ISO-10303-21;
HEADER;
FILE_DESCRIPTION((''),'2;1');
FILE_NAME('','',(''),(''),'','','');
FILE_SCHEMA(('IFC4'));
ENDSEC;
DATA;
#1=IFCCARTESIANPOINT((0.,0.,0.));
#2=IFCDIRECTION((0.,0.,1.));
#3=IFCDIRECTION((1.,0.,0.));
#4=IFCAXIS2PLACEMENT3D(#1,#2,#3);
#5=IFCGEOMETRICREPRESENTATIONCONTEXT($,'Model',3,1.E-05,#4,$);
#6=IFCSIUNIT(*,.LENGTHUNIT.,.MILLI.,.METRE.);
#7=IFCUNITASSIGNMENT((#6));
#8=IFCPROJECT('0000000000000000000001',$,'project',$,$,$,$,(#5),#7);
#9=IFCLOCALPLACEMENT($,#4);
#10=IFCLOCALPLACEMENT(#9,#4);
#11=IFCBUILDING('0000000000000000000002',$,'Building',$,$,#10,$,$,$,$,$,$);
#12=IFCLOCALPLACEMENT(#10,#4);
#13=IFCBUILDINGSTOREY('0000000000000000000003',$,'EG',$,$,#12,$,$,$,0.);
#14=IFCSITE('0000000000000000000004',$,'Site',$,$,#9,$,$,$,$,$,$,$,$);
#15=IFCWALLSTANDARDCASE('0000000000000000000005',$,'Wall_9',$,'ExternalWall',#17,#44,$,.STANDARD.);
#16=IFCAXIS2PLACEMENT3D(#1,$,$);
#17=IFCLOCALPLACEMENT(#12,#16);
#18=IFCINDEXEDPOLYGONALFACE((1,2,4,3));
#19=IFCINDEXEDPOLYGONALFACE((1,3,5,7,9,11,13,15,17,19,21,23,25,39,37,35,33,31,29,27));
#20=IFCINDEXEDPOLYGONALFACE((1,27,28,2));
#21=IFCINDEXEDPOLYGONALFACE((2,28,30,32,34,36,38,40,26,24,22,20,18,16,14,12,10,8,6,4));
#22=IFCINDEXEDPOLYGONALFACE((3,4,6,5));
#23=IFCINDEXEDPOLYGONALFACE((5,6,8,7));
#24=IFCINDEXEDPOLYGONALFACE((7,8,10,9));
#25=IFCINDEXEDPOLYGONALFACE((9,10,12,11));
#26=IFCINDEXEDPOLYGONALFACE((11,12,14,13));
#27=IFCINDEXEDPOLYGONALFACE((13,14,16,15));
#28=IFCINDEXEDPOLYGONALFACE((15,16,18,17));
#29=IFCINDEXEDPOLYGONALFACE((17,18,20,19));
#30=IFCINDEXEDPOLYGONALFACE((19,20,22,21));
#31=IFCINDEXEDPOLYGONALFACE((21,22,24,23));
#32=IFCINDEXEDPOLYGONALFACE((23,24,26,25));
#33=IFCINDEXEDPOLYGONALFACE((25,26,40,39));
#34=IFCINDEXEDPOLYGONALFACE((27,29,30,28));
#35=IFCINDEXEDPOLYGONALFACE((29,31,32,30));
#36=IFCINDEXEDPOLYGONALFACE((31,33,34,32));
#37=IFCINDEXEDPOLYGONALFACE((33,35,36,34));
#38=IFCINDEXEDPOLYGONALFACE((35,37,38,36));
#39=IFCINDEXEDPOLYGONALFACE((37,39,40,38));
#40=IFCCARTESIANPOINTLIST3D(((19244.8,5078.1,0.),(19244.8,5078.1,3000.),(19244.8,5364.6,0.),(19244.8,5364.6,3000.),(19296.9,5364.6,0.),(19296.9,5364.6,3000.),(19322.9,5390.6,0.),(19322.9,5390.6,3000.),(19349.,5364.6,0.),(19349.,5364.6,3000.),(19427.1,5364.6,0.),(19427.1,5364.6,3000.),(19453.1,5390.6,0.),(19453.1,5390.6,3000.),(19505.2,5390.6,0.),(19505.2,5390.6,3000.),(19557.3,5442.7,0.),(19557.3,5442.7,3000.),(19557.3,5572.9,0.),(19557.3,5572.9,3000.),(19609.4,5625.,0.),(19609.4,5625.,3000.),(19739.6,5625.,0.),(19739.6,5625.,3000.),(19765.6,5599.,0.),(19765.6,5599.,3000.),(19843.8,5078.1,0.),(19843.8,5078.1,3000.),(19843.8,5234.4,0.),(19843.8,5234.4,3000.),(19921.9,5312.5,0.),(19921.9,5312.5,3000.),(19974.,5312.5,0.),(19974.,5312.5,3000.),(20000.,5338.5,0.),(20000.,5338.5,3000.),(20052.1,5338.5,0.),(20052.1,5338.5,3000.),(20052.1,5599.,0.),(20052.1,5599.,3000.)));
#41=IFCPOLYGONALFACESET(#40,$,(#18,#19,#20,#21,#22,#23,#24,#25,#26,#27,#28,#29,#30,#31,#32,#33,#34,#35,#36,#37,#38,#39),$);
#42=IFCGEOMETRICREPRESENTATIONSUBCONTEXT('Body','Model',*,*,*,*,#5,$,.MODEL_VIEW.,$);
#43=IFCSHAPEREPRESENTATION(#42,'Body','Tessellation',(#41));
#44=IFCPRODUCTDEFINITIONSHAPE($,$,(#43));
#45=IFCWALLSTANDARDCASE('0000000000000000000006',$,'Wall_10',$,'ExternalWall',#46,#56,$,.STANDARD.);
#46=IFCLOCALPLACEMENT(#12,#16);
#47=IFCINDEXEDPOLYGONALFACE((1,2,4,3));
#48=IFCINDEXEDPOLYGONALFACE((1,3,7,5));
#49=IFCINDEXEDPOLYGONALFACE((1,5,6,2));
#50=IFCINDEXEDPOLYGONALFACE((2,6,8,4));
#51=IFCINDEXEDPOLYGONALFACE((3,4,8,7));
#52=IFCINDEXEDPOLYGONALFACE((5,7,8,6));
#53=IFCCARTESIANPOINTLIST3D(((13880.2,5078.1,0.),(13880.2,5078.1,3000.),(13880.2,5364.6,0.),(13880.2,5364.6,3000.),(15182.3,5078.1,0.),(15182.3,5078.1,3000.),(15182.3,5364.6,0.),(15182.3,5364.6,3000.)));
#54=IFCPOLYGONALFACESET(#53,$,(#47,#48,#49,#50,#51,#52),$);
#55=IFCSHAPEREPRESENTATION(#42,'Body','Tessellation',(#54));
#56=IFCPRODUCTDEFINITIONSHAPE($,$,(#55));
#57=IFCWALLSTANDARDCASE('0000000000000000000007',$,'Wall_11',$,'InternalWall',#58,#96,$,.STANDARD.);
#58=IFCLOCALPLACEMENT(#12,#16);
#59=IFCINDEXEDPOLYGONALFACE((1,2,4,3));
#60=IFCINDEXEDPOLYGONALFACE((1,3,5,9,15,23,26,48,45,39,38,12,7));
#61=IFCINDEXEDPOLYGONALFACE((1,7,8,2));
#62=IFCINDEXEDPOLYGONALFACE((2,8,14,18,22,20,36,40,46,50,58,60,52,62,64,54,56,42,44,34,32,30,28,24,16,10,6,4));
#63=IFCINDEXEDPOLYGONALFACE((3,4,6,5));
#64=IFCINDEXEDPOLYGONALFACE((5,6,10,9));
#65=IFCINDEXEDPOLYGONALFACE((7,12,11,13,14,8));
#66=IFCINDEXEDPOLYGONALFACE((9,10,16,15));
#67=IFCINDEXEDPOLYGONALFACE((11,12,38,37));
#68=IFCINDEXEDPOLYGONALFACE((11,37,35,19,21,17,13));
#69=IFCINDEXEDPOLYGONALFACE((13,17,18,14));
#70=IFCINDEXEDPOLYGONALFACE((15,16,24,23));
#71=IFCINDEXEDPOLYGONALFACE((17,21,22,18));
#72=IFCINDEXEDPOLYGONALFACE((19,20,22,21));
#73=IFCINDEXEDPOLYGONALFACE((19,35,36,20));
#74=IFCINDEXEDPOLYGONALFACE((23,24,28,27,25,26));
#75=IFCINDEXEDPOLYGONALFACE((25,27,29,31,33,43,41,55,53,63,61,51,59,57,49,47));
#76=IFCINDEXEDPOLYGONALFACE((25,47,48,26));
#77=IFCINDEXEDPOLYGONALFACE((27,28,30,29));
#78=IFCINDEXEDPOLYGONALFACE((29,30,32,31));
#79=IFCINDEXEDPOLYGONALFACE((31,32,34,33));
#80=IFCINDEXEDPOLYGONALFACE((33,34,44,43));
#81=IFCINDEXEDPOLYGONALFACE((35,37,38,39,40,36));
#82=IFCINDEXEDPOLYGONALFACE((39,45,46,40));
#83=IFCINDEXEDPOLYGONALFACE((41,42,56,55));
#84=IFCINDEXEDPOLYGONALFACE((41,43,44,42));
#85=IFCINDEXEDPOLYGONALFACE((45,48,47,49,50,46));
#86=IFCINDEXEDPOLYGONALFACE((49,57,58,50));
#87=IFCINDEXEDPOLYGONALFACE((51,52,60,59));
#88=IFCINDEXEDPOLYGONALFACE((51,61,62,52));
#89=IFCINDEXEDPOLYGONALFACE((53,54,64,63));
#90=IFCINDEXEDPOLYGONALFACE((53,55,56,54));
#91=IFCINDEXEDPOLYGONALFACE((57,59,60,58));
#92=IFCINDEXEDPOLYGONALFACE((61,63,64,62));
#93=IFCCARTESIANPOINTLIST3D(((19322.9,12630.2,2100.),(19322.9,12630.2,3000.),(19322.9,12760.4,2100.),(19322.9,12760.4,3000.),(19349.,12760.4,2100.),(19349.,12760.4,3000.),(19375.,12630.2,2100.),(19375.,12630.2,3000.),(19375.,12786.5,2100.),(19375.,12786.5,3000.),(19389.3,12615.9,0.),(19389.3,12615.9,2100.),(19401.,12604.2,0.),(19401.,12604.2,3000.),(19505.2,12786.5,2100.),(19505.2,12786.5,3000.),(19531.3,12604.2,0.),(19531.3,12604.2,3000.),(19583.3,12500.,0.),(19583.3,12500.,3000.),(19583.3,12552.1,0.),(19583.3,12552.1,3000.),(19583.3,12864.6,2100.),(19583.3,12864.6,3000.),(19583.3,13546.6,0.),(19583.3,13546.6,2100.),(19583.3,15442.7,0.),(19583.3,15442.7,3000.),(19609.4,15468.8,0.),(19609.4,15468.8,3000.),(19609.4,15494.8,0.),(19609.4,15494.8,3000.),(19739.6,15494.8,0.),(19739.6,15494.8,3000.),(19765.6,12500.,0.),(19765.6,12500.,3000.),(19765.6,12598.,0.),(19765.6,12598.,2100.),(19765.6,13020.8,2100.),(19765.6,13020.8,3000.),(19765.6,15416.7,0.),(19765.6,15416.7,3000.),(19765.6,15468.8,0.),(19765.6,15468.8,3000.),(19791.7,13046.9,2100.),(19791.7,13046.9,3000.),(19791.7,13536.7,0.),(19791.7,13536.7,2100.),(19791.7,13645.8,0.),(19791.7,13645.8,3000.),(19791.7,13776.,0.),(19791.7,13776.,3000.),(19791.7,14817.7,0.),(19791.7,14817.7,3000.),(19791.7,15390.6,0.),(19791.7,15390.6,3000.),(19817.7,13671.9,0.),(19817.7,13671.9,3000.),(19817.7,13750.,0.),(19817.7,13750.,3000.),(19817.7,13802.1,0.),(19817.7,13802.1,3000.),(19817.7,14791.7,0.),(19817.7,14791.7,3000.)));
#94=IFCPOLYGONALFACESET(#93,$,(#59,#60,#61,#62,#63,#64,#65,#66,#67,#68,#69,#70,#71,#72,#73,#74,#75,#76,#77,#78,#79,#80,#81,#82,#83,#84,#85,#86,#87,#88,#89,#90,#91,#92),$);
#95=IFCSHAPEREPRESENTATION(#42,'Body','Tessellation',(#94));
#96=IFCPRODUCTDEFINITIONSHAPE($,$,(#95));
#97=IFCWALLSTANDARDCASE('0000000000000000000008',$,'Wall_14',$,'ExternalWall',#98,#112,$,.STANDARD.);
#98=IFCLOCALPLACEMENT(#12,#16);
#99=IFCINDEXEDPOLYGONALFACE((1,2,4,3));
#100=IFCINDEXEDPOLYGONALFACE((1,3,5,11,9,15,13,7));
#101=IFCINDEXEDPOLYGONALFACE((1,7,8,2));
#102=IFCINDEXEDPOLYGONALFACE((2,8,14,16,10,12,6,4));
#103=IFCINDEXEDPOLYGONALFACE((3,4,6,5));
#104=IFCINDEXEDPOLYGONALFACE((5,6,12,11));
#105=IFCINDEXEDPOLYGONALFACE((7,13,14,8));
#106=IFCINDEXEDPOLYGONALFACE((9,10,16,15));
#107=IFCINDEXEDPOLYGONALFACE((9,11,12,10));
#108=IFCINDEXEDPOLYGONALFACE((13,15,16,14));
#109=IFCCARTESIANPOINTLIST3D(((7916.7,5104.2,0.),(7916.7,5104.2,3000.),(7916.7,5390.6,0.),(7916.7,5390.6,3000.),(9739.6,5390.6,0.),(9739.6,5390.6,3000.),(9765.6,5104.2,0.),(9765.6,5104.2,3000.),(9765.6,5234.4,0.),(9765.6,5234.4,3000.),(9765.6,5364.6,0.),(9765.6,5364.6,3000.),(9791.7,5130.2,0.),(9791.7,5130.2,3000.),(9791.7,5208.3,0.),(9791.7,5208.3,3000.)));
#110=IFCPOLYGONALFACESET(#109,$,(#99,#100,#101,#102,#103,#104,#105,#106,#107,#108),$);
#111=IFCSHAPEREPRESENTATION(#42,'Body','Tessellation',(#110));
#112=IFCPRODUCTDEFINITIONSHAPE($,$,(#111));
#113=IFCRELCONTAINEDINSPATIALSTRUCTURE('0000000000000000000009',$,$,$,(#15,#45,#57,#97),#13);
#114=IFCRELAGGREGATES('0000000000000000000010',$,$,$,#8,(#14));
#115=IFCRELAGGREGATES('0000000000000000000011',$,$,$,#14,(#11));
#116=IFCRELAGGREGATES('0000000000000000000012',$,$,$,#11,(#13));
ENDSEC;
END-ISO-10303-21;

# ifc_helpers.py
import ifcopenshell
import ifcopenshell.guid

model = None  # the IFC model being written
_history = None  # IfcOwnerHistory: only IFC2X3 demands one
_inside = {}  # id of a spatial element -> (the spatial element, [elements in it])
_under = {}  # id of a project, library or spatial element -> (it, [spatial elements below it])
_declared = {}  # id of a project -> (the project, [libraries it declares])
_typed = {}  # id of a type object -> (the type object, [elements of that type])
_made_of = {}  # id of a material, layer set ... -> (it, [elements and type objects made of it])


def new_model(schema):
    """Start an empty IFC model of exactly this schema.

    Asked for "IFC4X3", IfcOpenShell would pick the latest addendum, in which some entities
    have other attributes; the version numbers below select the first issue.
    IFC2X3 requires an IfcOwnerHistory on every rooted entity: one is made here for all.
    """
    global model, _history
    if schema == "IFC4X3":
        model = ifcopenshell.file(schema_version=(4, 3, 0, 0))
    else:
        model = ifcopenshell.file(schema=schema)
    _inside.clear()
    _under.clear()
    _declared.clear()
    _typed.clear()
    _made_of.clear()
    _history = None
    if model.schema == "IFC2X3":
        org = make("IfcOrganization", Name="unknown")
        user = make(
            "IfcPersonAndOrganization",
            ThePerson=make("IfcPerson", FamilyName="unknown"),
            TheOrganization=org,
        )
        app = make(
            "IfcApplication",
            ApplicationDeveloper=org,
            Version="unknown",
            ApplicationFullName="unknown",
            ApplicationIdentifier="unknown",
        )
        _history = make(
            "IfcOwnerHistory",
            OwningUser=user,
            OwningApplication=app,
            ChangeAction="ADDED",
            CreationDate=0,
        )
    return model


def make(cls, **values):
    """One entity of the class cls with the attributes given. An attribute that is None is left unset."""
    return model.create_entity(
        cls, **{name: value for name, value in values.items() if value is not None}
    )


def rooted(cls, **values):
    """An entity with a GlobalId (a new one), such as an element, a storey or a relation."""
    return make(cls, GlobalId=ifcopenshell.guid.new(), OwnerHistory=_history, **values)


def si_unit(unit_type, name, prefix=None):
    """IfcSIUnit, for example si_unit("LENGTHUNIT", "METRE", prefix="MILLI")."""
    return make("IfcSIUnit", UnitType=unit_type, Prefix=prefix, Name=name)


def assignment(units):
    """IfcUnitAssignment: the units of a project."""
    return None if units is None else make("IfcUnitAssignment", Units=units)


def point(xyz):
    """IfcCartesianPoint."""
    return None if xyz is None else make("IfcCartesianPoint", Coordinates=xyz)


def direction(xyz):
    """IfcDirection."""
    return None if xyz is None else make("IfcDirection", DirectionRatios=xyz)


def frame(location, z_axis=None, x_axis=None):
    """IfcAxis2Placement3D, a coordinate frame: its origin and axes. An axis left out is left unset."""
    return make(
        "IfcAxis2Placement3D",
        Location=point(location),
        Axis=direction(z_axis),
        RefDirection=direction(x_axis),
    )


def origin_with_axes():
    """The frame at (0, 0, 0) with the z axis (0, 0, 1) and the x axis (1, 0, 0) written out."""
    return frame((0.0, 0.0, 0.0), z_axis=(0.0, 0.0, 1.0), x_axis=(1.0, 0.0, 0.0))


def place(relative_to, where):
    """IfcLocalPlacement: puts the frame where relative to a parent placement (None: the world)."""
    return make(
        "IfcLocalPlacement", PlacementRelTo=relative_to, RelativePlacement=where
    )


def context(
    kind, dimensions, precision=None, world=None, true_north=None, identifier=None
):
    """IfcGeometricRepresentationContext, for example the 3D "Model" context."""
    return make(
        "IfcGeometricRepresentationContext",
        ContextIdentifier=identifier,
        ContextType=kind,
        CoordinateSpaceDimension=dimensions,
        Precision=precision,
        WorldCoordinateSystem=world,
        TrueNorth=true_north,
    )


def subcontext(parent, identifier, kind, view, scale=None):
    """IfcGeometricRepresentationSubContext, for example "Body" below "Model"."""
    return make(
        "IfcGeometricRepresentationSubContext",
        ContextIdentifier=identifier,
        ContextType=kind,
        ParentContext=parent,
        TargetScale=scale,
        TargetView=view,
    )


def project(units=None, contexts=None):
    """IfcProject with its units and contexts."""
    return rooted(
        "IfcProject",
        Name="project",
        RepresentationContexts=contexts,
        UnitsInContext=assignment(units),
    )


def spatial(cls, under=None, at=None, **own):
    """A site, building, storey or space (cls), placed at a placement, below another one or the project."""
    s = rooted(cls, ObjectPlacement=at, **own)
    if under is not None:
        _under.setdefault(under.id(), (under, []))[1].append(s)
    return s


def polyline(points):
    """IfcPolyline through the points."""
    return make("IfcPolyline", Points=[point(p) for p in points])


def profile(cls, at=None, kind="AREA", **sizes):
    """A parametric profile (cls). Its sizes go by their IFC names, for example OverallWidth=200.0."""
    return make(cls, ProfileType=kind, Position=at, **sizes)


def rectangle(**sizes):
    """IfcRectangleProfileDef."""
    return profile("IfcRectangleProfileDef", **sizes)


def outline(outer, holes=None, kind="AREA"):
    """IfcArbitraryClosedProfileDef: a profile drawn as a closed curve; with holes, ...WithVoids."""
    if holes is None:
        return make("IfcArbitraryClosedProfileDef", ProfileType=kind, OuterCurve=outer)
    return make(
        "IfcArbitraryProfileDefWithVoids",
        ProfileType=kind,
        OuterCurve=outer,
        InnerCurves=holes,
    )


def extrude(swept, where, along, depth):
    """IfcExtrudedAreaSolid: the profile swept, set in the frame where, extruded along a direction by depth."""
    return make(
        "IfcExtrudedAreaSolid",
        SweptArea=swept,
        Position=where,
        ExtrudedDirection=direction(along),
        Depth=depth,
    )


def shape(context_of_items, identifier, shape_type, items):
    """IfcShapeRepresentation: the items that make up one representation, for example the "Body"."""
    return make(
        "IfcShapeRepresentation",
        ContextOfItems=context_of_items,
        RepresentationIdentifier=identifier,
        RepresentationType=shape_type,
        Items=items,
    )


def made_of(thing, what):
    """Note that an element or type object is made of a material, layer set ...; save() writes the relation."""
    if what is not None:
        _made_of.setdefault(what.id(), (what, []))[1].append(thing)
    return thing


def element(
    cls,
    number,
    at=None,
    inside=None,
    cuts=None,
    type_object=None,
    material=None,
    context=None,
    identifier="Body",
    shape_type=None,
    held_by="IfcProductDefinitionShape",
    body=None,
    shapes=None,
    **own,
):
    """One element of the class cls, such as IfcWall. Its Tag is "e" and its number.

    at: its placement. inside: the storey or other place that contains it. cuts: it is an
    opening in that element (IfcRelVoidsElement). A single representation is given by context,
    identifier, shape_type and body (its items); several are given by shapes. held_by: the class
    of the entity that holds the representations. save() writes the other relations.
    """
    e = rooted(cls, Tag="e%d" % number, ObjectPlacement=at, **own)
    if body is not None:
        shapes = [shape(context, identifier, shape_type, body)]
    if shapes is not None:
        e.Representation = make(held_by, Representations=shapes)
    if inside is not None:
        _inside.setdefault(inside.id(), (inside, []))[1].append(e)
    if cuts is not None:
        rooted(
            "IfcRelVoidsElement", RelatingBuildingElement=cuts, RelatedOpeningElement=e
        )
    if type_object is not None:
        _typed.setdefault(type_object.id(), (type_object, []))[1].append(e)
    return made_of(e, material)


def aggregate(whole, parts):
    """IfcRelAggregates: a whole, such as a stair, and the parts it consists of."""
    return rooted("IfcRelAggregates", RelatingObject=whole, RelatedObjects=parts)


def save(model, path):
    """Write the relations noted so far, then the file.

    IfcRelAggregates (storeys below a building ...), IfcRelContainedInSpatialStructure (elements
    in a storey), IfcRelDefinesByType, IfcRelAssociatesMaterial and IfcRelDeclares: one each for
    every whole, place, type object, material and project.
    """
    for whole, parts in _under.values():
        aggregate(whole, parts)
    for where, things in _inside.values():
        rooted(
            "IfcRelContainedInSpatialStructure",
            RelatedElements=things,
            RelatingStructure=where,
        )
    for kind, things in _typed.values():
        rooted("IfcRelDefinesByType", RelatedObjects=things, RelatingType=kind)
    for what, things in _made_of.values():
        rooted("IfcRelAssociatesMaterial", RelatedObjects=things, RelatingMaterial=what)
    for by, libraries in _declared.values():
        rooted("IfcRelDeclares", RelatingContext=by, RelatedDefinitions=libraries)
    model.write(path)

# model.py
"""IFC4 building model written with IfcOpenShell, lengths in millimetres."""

from ifc_helpers import new_model, si_unit, frame, origin_with_axes, place, context, subcontext, project, spatial, polyline, rectangle, outline, extrude, element, save


model = new_model("IFC4")

# Units and contexts
model_context = context("Model", 3, precision=1e-05, world=origin_with_axes())
body_context = subcontext(model_context, "Body", "Model", "MODEL_VIEW")
ifc_project = project(units=[si_unit("LENGTHUNIT", "METRE", prefix="MILLI")], contexts=[model_context])

# Site, building, storey
site_placement = place(None, origin_with_axes())
site = spatial("IfcSite", under=ifc_project, at=site_placement, Name="Site")
building_placement = place(site_placement, origin_with_axes())
building = spatial("IfcBuilding", under=site, at=building_placement, Name="Building")
storey_placement = place(building_placement, origin_with_axes())
storey = spatial("IfcBuildingStorey", under=building, at=storey_placement, Name="EG", Elevation=0.0)

# Wall, openings
wall_1_placement = place(storey_placement, origin_with_axes())
wall_1 = element("IfcWallStandardCase", 1, at=wall_1_placement, inside=storey, Name="Wall_9", ObjectType="ExternalWall", PredefinedType="STANDARD", context=body_context, shape_type="SweptSolid", body=[
    extrude(outline(polyline([(19244.8, 5078.1, 0.0), (19244.8, 5364.6, 0.0), (19296.9, 5364.6, 0.0), (19322.9, 5390.6, 0.0), (19349.0, 5364.6, 0.0), (19427.1, 5364.6, 0.0), (19453.1, 5390.6, 0.0), (19505.2, 5390.6, 0.0), (19557.3, 5442.7, 0.0), (19557.3, 5572.9, 0.0), (19609.4, 5625.0, 0.0), (19739.6, 5625.0, 0.0), (19765.6, 5599.0, 0.0), (20052.1, 5599.0, 0.0), (20052.1, 5338.5, 0.0), (20000.0, 5338.5, 0.0), (19974.0, 5312.5, 0.0), (19921.9, 5312.5, 0.0), (19843.8, 5234.4, 0.0), (19843.8, 5078.1, 0.0), (19244.8, 5078.1, 0.0)])), origin_with_axes(), (0.0, 0.0, 1.0), 3000.0),
])
opening_1_placement = place(wall_1_placement, origin_with_axes())
element("IfcOpeningElement", 2, at=opening_1_placement, inside=storey, cuts=wall_1, context=body_context, shape_type="SweptSolid", body=[
    extrude(rectangle(XDim=1200.0, YDim=546.9), frame((18580.7, 5208.1, 1000.0), z_axis=(0.0, 0.0, 1.0), x_axis=(1.0, 0.0, 0.0)), (0.0, 0.0, 1.0), 1000.0),
])
opening_2_placement = place(wall_1_placement, origin_with_axes())
element("IfcOpeningElement", 3, at=opening_2_placement, inside=storey, cuts=wall_1, context=body_context, shape_type="SweptSolid", body=[
    extrude(rectangle(XDim=1200.0, YDim=546.9), frame((21822.9, 5507.8, 1000.0), z_axis=(0.0, 0.0, 1.0), x_axis=(1.0, 0.0, 0.0)), (0.0, 0.0, 1.0), 1000.0),
])

# Wall
wall_2_placement = place(storey_placement, origin_with_axes())
element("IfcWallStandardCase", 4, at=wall_2_placement, inside=storey, Name="Wall_10", ObjectType="ExternalWall", PredefinedType="STANDARD", context=body_context, shape_type="SweptSolid", body=[
    extrude(outline(polyline([(13880.2, 5078.1, 0.0), (13880.2, 5364.6, 0.0), (15182.3, 5364.6, 0.0), (15182.3, 5078.1, 0.0), (13880.2, 5078.1, 0.0)])), origin_with_axes(), (0.0, 0.0, 1.0), 3000.0),
])

# Walls, openings
wall_3_placement = place(storey_placement, origin_with_axes())
wall_3 = element("IfcWallStandardCase", 5, at=wall_3_placement, inside=storey, Name="Wall_11", ObjectType="InternalWall", PredefinedType="STANDARD", context=body_context, shape_type="SweptSolid", body=[
    extrude(outline(polyline([(19583.3, 12500.0, 0.0), (19583.3, 12552.1, 0.0), (19531.3, 12604.2, 0.0), (19401.0, 12604.2, 0.0), (19375.0, 12630.2, 0.0), (19322.9, 12630.2, 0.0), (19322.9, 12760.4, 0.0), (19349.0, 12760.4, 0.0), (19375.0, 12786.5, 0.0), (19505.2, 12786.5, 0.0), (19583.3, 12864.6, 0.0), (19583.3, 15442.7, 0.0), (19609.4, 15468.8, 0.0), (19609.4, 15494.8, 0.0), (19739.6, 15494.8, 0.0), (19765.6, 15468.8, 0.0), (19765.6, 15416.7, 0.0), (19791.7, 15390.6, 0.0), (19791.7, 14817.7, 0.0), (19817.7, 14791.7, 0.0), (19817.7, 13802.1, 0.0), (19791.7, 13776.0, 0.0), (19817.7, 13750.0, 0.0), (19817.7, 13671.9, 0.0), (19791.7, 13645.8, 0.0), (19791.7, 13046.9, 0.0), (19765.6, 13020.8, 0.0), (19765.6, 12500.0, 0.0), (19583.3, 12500.0, 0.0)])), origin_with_axes(), (0.0, 0.0, 1.0), 3000.0),
])
opening_3_placement = place(wall_3_placement, origin_with_axes())
element("IfcOpeningElement", 6, at=opening_3_placement, inside=storey, cuts=wall_3, context=body_context, shape_type="SweptSolid", body=[
    extrude(rectangle(XDim=938.9, YDim=454.6), frame((19565.6, 13077.5, 0.0), z_axis=(0.0, 0.0, 1.0), x_axis=(-0.047565, -0.998868, 0.0)), (0.0, 0.0, 1.0), 2100.0),
])
wall_4_placement = place(storey_placement, origin_with_axes())
wall_4 = element("IfcWallStandardCase", 7, at=wall_4_placement, inside=storey, Name="Wall_14", ObjectType="ExternalWall", PredefinedType="STANDARD", context=body_context, shape_type="SweptSolid", body=[
    extrude(outline(polyline([(7916.7, 5104.2, 0.0), (7916.7, 5390.6, 0.0), (9739.6, 5390.6, 0.0), (9765.6, 5364.6, 0.0), (9765.6, 5234.4, 0.0), (9791.7, 5208.3, 0.0), (9791.7, 5130.2, 0.0), (9765.6, 5104.2, 0.0), (7916.7, 5104.2, 0.0)])), origin_with_axes(), (0.0, 0.0, 1.0), 3000.0),
])
opening_4_placement = place(wall_4_placement, origin_with_axes())
element("IfcOpeningElement", 8, at=opening_4_placement, inside=storey, cuts=wall_4, context=body_context, shape_type="SweptSolid", body=[
    extrude(rectangle(XDim=1200.0, YDim=286.5), frame((10468.2, 5247.3, 1000.0), z_axis=(0.0, 0.0, 1.0), x_axis=(-1.0, 0.0, 0.0)), (0.0, 0.0, 1.0), 1000.0),
])

save(model, "model.ifc")
